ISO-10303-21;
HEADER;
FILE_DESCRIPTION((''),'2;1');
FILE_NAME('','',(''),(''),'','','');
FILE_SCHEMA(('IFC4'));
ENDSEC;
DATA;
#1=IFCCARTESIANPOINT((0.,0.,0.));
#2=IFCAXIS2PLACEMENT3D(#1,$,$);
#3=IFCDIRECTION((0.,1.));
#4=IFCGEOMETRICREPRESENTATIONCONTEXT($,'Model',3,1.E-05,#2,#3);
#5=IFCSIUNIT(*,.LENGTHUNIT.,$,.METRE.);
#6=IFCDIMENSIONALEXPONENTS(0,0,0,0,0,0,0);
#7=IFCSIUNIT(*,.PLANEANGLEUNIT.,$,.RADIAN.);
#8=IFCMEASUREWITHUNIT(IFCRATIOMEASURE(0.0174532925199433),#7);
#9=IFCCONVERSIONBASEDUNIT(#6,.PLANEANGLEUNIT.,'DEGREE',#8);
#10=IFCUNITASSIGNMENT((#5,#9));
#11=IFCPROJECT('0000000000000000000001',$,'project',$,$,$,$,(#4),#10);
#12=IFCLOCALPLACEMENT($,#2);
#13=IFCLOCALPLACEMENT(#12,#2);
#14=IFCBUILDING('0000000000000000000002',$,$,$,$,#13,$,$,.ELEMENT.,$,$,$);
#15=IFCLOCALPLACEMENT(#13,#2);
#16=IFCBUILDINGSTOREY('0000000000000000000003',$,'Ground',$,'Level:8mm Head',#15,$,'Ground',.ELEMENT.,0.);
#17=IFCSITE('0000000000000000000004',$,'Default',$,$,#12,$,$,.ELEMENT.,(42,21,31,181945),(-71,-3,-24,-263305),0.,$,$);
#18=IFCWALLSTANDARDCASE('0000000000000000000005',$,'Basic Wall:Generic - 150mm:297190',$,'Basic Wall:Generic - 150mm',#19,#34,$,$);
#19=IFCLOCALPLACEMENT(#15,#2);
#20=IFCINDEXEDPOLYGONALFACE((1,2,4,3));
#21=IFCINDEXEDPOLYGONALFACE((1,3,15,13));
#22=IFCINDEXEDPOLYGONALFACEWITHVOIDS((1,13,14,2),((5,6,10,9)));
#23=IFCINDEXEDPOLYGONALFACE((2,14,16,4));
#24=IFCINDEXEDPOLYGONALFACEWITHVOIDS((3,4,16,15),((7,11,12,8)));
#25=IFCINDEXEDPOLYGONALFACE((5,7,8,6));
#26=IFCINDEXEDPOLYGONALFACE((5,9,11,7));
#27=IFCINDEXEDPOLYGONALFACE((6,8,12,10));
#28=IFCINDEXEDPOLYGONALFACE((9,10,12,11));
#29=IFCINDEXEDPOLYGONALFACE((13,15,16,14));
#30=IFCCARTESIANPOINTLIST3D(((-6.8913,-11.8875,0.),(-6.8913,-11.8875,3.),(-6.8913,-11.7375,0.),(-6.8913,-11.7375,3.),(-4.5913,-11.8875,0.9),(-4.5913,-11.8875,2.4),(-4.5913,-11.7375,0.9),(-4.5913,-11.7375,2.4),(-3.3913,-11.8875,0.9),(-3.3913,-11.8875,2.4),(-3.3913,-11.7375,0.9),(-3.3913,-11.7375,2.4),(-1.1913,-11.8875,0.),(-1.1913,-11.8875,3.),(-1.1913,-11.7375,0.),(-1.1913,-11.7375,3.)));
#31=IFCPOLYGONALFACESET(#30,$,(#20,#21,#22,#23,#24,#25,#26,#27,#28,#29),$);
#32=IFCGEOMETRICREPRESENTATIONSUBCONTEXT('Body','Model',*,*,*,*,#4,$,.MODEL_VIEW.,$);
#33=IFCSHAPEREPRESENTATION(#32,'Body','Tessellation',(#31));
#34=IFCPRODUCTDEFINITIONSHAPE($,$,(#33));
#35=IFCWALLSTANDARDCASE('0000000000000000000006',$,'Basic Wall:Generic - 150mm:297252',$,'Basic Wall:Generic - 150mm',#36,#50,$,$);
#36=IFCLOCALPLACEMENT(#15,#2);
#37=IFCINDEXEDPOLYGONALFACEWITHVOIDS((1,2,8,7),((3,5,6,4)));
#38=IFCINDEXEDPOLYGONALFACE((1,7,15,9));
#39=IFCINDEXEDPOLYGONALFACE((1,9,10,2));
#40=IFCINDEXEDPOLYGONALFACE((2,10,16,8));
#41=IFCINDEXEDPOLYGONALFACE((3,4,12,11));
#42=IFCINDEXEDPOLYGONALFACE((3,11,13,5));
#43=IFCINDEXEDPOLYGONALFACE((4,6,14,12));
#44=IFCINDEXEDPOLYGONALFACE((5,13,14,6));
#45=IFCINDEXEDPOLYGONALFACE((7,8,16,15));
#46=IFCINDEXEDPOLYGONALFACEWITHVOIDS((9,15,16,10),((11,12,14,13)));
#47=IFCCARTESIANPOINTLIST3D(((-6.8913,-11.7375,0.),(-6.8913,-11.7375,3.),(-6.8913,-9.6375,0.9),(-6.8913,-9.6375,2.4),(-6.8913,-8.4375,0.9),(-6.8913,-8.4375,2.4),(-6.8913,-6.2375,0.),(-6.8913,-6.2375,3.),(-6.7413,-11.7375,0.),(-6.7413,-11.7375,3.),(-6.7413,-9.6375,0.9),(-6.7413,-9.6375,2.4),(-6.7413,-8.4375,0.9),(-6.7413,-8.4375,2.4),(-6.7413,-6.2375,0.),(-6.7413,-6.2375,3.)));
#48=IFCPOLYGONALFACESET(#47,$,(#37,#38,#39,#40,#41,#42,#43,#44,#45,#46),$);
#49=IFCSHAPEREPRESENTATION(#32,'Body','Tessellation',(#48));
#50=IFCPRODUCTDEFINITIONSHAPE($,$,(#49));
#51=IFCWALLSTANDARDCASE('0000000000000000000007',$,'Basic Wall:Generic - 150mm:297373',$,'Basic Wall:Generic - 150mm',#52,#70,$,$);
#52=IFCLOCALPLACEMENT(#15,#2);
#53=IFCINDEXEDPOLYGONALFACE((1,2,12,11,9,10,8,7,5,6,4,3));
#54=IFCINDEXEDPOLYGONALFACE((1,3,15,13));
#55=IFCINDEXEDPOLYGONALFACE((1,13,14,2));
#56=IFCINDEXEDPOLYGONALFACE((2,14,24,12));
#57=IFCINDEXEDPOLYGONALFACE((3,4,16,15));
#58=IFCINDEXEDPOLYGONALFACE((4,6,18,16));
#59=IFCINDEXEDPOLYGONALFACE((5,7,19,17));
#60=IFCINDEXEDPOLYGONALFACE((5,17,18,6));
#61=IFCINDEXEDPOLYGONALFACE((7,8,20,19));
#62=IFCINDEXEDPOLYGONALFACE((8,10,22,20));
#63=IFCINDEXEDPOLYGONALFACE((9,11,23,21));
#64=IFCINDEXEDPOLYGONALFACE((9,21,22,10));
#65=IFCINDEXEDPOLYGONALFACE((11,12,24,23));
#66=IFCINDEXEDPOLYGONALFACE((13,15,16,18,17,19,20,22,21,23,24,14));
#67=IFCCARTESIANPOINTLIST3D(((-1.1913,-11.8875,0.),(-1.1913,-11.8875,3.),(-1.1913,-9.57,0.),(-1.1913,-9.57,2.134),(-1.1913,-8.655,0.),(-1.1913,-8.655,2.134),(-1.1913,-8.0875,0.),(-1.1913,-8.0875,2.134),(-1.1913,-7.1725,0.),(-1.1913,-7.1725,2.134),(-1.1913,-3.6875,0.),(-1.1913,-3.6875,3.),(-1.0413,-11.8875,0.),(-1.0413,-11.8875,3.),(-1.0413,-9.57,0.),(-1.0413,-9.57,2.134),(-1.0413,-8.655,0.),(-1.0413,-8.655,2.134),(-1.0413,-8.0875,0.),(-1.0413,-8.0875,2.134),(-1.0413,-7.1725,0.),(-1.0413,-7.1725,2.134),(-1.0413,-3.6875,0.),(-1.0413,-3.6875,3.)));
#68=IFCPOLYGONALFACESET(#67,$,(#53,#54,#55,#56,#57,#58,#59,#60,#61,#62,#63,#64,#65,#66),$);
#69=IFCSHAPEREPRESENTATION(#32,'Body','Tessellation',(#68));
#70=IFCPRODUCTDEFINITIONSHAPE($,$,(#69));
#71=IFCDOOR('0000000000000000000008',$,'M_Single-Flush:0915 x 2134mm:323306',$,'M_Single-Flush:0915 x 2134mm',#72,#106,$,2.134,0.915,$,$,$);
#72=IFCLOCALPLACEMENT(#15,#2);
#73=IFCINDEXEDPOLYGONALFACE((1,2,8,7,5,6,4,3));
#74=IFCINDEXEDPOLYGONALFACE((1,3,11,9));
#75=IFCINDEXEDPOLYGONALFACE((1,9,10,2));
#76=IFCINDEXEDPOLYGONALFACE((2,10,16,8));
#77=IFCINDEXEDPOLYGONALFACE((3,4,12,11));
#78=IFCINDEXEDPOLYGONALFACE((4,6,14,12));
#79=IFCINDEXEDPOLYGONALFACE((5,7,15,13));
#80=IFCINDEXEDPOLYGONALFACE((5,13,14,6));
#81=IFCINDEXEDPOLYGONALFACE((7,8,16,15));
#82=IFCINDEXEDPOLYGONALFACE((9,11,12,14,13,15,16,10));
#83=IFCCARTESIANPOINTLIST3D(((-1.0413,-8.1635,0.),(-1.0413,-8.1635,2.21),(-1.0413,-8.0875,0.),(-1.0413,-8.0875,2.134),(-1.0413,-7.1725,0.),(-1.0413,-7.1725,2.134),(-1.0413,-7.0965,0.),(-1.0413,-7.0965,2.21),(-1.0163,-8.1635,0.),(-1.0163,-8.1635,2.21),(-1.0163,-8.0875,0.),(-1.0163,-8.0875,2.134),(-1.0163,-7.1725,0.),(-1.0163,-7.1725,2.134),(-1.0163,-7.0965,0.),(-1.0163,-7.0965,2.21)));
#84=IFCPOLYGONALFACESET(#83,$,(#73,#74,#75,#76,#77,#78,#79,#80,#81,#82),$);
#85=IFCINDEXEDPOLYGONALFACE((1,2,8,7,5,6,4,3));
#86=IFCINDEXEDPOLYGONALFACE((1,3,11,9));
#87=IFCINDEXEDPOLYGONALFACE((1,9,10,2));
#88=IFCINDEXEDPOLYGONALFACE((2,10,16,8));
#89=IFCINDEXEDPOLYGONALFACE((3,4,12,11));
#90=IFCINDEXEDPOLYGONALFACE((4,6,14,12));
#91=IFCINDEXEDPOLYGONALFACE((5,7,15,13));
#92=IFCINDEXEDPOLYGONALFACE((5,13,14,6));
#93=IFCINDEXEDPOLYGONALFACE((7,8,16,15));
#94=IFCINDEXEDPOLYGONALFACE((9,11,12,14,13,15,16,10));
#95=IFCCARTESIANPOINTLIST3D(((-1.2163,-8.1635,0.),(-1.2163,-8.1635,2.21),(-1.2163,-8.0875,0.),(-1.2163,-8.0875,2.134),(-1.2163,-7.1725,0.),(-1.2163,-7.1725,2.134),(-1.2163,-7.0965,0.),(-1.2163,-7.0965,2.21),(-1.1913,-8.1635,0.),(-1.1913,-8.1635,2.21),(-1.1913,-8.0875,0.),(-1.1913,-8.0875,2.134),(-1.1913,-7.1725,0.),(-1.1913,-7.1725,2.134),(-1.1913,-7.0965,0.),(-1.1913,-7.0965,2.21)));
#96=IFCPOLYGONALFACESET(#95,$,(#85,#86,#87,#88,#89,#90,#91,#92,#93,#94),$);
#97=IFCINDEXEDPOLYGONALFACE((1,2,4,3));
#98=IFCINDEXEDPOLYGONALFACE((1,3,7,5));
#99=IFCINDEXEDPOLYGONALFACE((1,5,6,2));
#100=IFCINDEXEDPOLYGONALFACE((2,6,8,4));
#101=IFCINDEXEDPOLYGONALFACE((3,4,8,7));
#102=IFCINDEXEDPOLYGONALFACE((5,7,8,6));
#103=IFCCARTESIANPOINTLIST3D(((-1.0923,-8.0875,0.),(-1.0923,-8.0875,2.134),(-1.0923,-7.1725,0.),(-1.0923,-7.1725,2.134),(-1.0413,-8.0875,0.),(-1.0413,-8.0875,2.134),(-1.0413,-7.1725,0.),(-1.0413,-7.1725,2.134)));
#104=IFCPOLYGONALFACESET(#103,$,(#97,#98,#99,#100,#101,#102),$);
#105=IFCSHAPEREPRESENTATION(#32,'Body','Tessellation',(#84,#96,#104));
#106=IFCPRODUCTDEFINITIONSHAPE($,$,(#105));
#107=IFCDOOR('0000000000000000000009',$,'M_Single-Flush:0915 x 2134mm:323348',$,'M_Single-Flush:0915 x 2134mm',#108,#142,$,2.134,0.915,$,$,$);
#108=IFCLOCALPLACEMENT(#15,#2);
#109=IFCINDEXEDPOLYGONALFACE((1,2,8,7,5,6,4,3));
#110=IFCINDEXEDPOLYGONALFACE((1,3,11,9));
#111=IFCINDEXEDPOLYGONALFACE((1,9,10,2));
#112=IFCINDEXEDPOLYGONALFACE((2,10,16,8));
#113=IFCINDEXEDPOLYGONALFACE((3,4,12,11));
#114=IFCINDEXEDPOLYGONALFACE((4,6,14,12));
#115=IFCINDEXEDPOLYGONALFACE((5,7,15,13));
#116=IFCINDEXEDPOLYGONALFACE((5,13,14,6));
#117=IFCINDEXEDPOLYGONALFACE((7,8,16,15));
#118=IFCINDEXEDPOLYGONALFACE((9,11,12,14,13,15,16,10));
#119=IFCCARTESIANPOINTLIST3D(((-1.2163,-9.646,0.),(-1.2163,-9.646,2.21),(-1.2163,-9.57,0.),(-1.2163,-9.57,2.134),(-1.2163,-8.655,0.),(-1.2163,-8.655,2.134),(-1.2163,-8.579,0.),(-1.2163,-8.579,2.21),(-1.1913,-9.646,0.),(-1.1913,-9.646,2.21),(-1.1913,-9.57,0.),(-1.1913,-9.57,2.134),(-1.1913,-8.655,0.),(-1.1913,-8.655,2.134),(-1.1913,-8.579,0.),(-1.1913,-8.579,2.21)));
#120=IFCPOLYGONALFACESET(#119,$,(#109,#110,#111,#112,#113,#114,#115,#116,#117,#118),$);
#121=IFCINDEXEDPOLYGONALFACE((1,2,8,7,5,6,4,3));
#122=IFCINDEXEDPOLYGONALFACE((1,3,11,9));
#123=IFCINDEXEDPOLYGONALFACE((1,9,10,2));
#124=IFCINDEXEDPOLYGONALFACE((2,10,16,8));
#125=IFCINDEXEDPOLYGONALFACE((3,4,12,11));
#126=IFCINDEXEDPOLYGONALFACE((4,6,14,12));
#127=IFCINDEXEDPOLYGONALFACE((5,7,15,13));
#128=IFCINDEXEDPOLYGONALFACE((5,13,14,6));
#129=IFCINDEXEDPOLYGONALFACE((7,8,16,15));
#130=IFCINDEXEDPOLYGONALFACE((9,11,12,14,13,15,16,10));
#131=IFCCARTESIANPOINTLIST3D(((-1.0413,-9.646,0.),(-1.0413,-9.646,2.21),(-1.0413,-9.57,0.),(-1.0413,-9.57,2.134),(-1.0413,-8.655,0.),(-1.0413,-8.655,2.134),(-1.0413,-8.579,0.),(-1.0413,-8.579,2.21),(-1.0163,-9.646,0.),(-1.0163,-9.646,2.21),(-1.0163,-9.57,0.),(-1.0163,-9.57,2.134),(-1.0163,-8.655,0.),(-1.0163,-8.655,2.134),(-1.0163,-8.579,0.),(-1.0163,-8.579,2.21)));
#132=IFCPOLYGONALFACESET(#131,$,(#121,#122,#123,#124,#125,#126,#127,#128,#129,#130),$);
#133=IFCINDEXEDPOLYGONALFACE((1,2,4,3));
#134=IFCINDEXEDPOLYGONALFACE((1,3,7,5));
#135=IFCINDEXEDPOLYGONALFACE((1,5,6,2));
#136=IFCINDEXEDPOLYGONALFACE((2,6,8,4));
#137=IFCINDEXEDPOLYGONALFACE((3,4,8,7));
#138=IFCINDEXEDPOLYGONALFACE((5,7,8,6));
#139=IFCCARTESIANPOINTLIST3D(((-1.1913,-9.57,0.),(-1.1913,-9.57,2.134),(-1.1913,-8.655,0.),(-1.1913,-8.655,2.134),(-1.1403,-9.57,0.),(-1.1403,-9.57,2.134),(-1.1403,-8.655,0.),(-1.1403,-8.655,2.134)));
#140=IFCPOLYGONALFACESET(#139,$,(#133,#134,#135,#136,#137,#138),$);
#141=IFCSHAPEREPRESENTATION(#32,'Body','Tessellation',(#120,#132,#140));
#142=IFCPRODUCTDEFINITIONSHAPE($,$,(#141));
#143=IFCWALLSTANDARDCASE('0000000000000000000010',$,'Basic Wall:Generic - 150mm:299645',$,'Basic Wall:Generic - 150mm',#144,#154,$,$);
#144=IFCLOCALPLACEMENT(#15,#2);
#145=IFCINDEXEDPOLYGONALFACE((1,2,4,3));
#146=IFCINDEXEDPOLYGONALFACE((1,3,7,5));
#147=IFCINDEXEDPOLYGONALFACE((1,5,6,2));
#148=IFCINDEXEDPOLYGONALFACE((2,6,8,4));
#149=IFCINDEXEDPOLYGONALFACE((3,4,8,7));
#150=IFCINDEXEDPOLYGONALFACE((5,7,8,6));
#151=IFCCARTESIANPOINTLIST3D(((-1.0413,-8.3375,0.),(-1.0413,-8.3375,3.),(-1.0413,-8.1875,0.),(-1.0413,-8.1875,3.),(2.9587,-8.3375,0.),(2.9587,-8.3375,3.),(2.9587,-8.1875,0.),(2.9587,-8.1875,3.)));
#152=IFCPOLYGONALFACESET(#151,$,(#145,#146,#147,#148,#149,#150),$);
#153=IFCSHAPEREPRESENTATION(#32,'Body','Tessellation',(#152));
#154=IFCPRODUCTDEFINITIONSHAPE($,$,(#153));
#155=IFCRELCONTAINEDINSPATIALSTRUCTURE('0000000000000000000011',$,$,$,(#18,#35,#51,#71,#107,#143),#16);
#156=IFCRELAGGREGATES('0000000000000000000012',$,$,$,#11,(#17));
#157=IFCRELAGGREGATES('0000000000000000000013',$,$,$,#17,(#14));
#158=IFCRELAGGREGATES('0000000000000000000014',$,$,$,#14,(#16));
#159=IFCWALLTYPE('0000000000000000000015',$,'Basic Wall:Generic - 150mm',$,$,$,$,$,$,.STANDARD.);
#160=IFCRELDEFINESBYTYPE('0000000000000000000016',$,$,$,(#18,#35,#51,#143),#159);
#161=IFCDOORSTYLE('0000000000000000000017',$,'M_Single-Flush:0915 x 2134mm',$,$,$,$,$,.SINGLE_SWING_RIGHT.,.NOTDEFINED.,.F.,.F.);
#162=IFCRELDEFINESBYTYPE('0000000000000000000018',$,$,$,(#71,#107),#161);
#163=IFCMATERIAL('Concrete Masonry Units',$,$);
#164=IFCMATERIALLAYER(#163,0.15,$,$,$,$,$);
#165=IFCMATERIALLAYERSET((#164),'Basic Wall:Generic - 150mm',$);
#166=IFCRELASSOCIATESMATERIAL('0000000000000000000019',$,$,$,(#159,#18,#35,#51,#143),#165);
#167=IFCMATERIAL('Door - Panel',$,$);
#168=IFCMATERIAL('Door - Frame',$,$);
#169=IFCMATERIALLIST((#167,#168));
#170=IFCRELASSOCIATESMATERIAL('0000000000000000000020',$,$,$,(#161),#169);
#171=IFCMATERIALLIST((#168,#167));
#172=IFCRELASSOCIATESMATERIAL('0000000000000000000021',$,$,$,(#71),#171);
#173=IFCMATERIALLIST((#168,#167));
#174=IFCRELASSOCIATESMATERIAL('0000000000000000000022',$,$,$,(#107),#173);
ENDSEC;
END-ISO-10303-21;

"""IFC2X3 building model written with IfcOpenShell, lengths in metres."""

from ifc_helpers import new_model, entity, si_unit, converted_unit, direction, frame, frame_2d, origin, place, context, subcontext, project, spatial, polyline, rectangle, outline, extrude, source, transform, mapped, material, material_list, layer, layer_set, layer_usage, type_object, type_shapes, element, fill, save


model = new_model("IFC2X3")

# Units and contexts
model_context = context("Model", 3, precision=1e-05, world=origin(), true_north=direction((0.0, 1.0)))
body_context = subcontext(model_context, "Body", "Model", "MODEL_VIEW")
ifc_project = project(units=[si_unit("LENGTHUNIT", "METRE"), converted_unit("PLANEANGLEUNIT", "DEGREE", entity("IfcRatioMeasure", 0.0174532925199433), si_unit("PLANEANGLEUNIT", "RADIAN"), dimensions=[0, 0, 0, 0, 0, 0, 0])], contexts=[model_context])

# Site, building, storey
site_placement = place(None, origin())
site = spatial("IfcSite", under=ifc_project, at=site_placement, Name="Default", CompositionType="ELEMENT", RefLatitude=(42, 21, 31, 181945), RefLongitude=(-71, -3, -24, -263305), RefElevation=0.0)
building_placement = place(site_placement, origin())
building = spatial("IfcBuilding", under=site, at=building_placement, CompositionType="ELEMENT")
storey_placement = place(building_placement, origin())
storey = spatial("IfcBuildingStorey", under=building, at=storey_placement, Name="Ground", ObjectType="Level:8mm Head", LongName="Ground", CompositionType="ELEMENT", Elevation=0.0)

# Walls, openings
ifc_material_1 = material(Name="Concrete Masonry Units")
ifc_layer = layer(ifc_material_1, 0.15)
ifc_layer_set = layer_set([ifc_layer], Name="Basic Wall:Generic - 150mm")
ifc_layer_usage_1 = layer_usage(ifc_layer_set, "AXIS2", "NEGATIVE", 0.075)
wall_type = type_object("IfcWallType", Name="Basic Wall:Generic - 150mm", PredefinedType="STANDARD", material=ifc_layer_set)
wall_1_placement = place(storey_placement, frame((-1.1913, -11.8125, 0.0), z_axis=(0.0, 0.0, 1.0), x_axis=(-1.0, 0.0, 0.0)))
wall_1 = element("IfcWallStandardCase", 1, at=wall_1_placement, inside=storey, type_object=wall_type, material=ifc_layer_usage_1, Name="Basic Wall:Generic - 150mm:297190", ObjectType="Basic Wall:Generic - 150mm", context=body_context, shape_type="SweptSolid", body=[
    extrude(rectangle(XDim=5.7, YDim=0.15, at=frame_2d((2.85, 0.0), x_axis=(-1.0, 0.0))), origin(), (0.0, 0.0, 1.0), 3.0),
])
opening_1_placement = place(wall_1_placement, frame((3.4, 0.075, 0.9)))
element("IfcOpeningElement", 2, at=opening_1_placement, cuts=wall_1, ObjectType="Opening", context=body_context, shape_type="SweptSolid", body=[
    extrude(rectangle(XDim=1.5, YDim=1.2, at=frame_2d((0.75, 0.6), x_axis=(-1.0, 0.0))), frame((0.0, 0.0, 0.0), z_axis=(0.0, -1.0, 0.0), x_axis=(0.0, 0.0, 1.0)), (0.0, 0.0, 1.0), 0.15),
])
ifc_layer_usage_2 = layer_usage(ifc_layer_set, "AXIS2", "POSITIVE", -0.075)
wall_2_placement = place(storey_placement, frame((-6.8163, -11.7375, 0.0), z_axis=(0.0, 0.0, 1.0), x_axis=(0.0, 1.0, 0.0)))
wall_2 = element("IfcWallStandardCase", 3, at=wall_2_placement, inside=storey, type_object=wall_type, material=ifc_layer_usage_2, Name="Basic Wall:Generic - 150mm:297252", ObjectType="Basic Wall:Generic - 150mm", context=body_context, shape_type="SweptSolid", body=[
    extrude(rectangle(XDim=5.5, YDim=0.15, at=frame_2d((2.75, 0.0), x_axis=(-1.0, 0.0))), origin(), (0.0, 0.0, 1.0), 3.0),
])
opening_2_placement = place(wall_2_placement, frame((3.3, 0.075, 0.9)))
element("IfcOpeningElement", 4, at=opening_2_placement, cuts=wall_2, ObjectType="Opening", context=body_context, shape_type="SweptSolid", body=[
    extrude(rectangle(XDim=1.5, YDim=1.2, at=frame_2d((0.75, 0.6), x_axis=(-1.0, 0.0))), frame((0.0, 0.0, 0.0), z_axis=(0.0, -1.0, 0.0), x_axis=(0.0, 0.0, 1.0)), (0.0, 0.0, 1.0), 0.15),
])

# Wall, openings, doors
ifc_layer_usage_3 = layer_usage(ifc_layer_set, "AXIS2", "POSITIVE", -0.075)
wall_3_placement = place(storey_placement, frame((-1.1163, -11.8875, 0.0), z_axis=(0.0, 0.0, 1.0), x_axis=(0.0, 1.0, 0.0)))
wall_3 = element("IfcWallStandardCase", 5, at=wall_3_placement, inside=storey, type_object=wall_type, material=ifc_layer_usage_3, Name="Basic Wall:Generic - 150mm:297373", ObjectType="Basic Wall:Generic - 150mm", context=body_context, shape_type="SweptSolid", body=[
    extrude(rectangle(XDim=8.2, YDim=0.15, at=frame_2d((4.1, 0.0), x_axis=(-1.0, 0.0))), origin(), (0.0, 0.0, 1.0), 3.0),
])
opening_3_placement = place(wall_3_placement, frame((4.715, 0.075, 0.0)))
opening_3 = element("IfcOpeningElement", 6, at=opening_3_placement, cuts=wall_3, ObjectType="Opening", context=body_context, shape_type="SweptSolid", body=[
    extrude(rectangle(XDim=0.915, YDim=2.134, at=frame_2d((1.067, 0.4575), x_axis=(0.0, 1.0))), frame((0.0, 0.0, 0.0), z_axis=(0.0, -1.0, 0.0), x_axis=(0.0, 0.0, 1.0)), (0.0, 0.0, 1.0), 0.15),
])
opening_4_placement = place(wall_3_placement, frame((2.3175, -0.075, 0.0)))
opening_4 = element("IfcOpeningElement", 7, at=opening_4_placement, cuts=wall_3, ObjectType="Opening", context=body_context, shape_type="SweptSolid", body=[
    extrude(rectangle(XDim=0.915, YDim=2.134, at=frame_2d((1.067, 0.4575), x_axis=(0.0, 1.0))), frame((0.0, 0.0, 0.0), z_axis=(0.0, 1.0, 0.0), x_axis=(0.0, 0.0, 1.0)), (0.0, 0.0, 1.0), 0.15),
])
ifc_material_2 = material(Name="Door - Frame")
ifc_material_3 = material(Name="Door - Panel")
ifc_material_list_1 = material_list([ifc_material_2, ifc_material_3])
ifc_material_list_2 = material_list([ifc_material_3, ifc_material_2])
door_style = type_object("IfcDoorStyle", Name="M_Single-Flush:0915 x 2134mm", ConstructionType="NOTDEFINED", OperationType="SINGLE_SWING_RIGHT", ParameterTakesPrecedence=False, Sizeable=False, material=ifc_material_list_2)
shared_shape_1 = source(origin(), body_context, "Body", "SweptSolid", [
    extrude(outline(polyline([(-0.5335, -1.124), (0.5335, -1.124), (0.5335, 1.086), (0.4575, 1.086), (0.4575, -1.048), (-0.4575, -1.048), (-0.4575, 1.086), (-0.5335, 1.086), (-0.5335, -1.124)])), frame((0.4575, 0.15, 1.086), z_axis=(0.0, 1.0, 0.0), x_axis=(1.0, 0.0, 0.0)), (0.0, 0.0, 1.0), 0.025),
    extrude(outline(polyline([(-1.124, -0.5335), (1.086, -0.5335), (1.086, -0.4575), (-1.048, -0.4575), (-1.048, 0.4575), (1.086, 0.4575), (1.086, 0.5335), (-1.124, 0.5335), (-1.124, -0.5335)])), frame((0.4575, -0.025, 1.086), z_axis=(0.0, 1.0, 0.0), x_axis=(0.0, 0.0, -1.0)), (0.0, 0.0, 1.0), 0.025),
    extrude(rectangle(XDim=0.051, YDim=0.915, at=frame_2d((0.0, 0.0), x_axis=(1.0, 0.0))), frame((0.4575, 0.1245, 0.0), z_axis=(0.0, 0.0, 1.0), x_axis=(0.0, 1.0, 0.0)), (0.0, 0.0, 1.0), 2.134),
])
type_shapes(door_style, [shared_shape_1])
door_1_placement = place(opening_3_placement, frame((0.0, 0.0, 0.0), z_axis=(0.0, 0.0, 1.0), x_axis=(-1.0, 0.0, 0.0)))
door_1 = element("IfcDoor", 8, at=door_1_placement, inside=storey, type_object=door_style, material=ifc_material_list_1, Name="M_Single-Flush:0915 x 2134mm:323306", ObjectType="M_Single-Flush:0915 x 2134mm", OverallHeight=2.134, OverallWidth=0.915, context=body_context, shape_type="MappedRepresentation", body=[
    mapped(shared_shape_1, transform((0.0, 0.0, 0.0), scale=1.0)),
])
fill(opening_3, door_1)
ifc_material_list_3 = material_list([ifc_material_2, ifc_material_3])
door_2_placement = place(opening_4_placement, origin())
door_2 = element("IfcDoor", 9, at=door_2_placement, inside=storey, type_object=door_style, material=ifc_material_list_3, Name="M_Single-Flush:0915 x 2134mm:323348", ObjectType="M_Single-Flush:0915 x 2134mm", OverallHeight=2.134, OverallWidth=0.915, context=body_context, shape_type="MappedRepresentation", body=[
    mapped(shared_shape_1, transform((0.0, 0.0, 0.0), scale=1.0)),
])
fill(opening_4, door_2)

# Wall
ifc_layer_usage_4 = layer_usage(ifc_layer_set, "AXIS2", "POSITIVE", -0.075)
wall_4_placement = place(storey_placement, frame((2.9587, -8.2625, 0.0), z_axis=(0.0, 0.0, 1.0), x_axis=(-1.0, 0.0, 0.0)))
element("IfcWallStandardCase", 10, at=wall_4_placement, inside=storey, type_object=wall_type, material=ifc_layer_usage_4, Name="Basic Wall:Generic - 150mm:299645", ObjectType="Basic Wall:Generic - 150mm", context=body_context, shape_type="SweptSolid", body=[
    extrude(rectangle(XDim=4.0, YDim=0.15, at=frame_2d((2.0, 0.0), x_axis=(-1.0, 0.0))), origin(), (0.0, 0.0, 1.0), 3.0),
])

save(model, "model.ifc")
